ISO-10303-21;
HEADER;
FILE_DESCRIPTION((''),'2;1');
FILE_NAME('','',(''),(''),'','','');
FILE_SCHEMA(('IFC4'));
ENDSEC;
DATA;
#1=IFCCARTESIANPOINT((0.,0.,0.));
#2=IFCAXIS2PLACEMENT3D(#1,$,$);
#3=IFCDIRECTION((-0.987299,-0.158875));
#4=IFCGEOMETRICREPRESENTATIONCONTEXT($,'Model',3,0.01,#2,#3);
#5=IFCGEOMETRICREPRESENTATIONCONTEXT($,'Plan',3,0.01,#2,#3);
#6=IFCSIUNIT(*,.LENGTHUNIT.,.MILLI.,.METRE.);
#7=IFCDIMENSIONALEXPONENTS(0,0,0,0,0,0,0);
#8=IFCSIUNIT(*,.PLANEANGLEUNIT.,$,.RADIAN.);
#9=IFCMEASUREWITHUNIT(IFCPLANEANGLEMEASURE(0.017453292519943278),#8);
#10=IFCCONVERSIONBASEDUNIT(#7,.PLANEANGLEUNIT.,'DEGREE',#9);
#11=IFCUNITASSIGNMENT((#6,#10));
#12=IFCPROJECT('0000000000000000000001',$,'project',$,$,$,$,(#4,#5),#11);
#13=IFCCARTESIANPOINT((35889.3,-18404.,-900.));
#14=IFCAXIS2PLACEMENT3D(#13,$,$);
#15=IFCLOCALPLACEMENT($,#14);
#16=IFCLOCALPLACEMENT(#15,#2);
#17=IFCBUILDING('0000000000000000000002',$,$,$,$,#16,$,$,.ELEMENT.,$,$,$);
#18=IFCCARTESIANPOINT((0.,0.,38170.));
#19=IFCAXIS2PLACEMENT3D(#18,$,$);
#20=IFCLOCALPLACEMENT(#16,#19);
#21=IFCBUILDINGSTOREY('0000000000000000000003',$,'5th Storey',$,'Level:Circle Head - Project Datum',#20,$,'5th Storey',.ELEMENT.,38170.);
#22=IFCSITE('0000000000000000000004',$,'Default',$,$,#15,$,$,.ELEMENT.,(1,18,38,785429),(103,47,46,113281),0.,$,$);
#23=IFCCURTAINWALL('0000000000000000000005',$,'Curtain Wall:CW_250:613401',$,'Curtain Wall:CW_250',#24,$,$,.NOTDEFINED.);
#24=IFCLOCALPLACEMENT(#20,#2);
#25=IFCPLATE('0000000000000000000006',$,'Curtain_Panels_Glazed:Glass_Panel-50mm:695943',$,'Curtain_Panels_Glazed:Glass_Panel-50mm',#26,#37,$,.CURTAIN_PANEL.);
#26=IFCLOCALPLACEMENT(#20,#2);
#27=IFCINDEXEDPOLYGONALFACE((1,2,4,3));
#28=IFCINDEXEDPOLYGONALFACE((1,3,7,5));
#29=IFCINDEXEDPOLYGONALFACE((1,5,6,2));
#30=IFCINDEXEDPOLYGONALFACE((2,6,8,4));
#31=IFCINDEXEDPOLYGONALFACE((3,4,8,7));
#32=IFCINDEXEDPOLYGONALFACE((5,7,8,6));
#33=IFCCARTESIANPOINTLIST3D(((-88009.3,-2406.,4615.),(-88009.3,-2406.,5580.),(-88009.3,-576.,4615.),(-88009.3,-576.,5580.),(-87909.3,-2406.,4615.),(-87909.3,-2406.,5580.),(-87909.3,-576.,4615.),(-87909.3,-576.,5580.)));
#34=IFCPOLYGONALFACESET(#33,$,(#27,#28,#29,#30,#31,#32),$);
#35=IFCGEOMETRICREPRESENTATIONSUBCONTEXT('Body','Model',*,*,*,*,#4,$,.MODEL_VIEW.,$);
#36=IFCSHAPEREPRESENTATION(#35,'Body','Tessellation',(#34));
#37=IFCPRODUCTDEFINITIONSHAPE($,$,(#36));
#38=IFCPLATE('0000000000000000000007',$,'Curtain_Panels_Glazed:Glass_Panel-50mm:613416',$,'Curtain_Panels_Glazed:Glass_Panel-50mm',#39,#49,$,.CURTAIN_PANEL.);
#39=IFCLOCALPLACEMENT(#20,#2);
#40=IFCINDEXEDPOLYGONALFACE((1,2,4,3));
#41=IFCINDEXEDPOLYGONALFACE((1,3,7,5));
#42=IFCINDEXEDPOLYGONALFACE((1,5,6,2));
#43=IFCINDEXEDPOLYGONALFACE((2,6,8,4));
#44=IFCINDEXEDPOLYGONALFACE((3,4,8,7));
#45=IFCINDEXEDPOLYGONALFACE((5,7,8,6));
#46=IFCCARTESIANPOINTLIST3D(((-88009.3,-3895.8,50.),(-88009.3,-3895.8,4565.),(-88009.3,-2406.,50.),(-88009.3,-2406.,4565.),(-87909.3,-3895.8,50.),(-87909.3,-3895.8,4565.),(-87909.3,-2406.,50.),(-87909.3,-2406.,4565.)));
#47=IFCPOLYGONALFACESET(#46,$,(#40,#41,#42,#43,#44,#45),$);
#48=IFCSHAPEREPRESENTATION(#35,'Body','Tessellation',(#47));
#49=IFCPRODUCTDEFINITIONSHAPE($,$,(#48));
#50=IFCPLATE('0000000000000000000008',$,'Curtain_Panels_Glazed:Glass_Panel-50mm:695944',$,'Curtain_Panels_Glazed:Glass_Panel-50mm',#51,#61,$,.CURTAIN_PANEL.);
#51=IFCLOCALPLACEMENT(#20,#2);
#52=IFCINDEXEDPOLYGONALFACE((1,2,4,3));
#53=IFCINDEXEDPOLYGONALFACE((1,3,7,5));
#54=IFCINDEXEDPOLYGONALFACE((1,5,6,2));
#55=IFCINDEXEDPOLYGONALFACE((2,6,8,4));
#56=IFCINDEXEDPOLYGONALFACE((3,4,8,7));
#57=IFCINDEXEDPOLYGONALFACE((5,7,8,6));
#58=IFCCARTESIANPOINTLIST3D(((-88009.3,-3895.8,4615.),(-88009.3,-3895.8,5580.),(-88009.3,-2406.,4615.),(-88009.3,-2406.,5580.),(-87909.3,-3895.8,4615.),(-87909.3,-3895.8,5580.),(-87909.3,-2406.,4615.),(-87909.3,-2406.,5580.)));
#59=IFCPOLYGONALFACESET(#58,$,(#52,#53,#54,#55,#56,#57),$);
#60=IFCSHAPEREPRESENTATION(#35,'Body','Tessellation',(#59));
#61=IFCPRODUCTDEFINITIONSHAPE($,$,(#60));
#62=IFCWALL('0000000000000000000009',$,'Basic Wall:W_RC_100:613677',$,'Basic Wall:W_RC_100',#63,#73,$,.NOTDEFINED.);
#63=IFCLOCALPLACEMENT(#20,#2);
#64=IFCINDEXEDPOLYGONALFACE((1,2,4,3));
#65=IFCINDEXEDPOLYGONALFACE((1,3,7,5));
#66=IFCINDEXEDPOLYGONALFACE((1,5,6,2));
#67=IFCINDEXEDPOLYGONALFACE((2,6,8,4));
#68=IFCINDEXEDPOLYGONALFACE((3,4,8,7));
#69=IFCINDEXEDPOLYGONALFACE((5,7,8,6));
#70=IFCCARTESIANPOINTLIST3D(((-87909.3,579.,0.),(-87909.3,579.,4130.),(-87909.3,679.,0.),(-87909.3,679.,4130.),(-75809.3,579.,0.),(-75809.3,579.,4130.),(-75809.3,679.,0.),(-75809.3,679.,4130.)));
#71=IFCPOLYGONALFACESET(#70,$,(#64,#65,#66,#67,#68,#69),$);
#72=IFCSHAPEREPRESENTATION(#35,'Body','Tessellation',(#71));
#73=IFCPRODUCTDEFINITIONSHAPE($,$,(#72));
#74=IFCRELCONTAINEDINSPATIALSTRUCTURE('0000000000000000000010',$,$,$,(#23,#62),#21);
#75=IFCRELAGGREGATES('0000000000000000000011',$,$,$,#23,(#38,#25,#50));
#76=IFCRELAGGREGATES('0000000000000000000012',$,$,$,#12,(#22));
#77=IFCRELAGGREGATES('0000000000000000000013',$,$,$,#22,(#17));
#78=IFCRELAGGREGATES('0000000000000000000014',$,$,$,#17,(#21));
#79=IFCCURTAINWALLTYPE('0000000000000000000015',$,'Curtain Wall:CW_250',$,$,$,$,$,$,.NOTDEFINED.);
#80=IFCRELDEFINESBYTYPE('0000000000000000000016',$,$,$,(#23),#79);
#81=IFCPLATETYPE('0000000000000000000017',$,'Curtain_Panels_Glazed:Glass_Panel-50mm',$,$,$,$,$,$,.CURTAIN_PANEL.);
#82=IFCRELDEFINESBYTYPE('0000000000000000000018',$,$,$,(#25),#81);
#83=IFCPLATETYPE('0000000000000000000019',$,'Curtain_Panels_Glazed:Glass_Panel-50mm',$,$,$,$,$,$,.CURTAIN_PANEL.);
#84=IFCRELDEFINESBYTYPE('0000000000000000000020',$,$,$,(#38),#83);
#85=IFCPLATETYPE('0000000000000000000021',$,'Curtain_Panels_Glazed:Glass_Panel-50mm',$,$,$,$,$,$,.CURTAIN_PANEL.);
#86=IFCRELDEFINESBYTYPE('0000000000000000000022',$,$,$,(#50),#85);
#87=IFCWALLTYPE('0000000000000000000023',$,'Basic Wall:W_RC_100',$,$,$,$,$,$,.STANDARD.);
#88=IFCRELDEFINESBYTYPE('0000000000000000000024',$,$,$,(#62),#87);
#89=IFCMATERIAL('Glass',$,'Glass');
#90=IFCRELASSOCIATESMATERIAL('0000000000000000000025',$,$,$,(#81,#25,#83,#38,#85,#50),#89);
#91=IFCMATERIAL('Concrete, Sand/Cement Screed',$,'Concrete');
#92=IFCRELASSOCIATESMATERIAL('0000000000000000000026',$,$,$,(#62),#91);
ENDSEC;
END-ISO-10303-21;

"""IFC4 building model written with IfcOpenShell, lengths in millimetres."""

from ifc_helpers import new_model, entity, si_unit, converted_unit, direction, frame, origin, place, context, subcontext, project, spatial, indexed_curve, outline, extrude, source, transform, mapped, material, type_object, type_shapes, element, aggregate, save


model = new_model("IFC4")

# Units and contexts
model_context = context("Model", 3, precision=0.01, world=origin(), true_north=direction((-0.987299, -0.158875)))
plan_context = context("Plan", 3, precision=0.01, world=origin(), true_north=direction((-0.987299, -0.158875)))
body_context = subcontext(model_context, "Body", "Model", "MODEL_VIEW")
ifc_project = project(units=[si_unit("LENGTHUNIT", "METRE", prefix="MILLI"), converted_unit("PLANEANGLEUNIT", "DEGREE", entity("IfcPlaneAngleMeasure", 0.017453292519943278), si_unit("PLANEANGLEUNIT", "RADIAN"), dimensions=[0, 0, 0, 0, 0, 0, 0])], contexts=[model_context, plan_context])

# Site, building, storey
site_placement = place(None, frame((35889.3, -18404.0, -900.0)))
site = spatial("IfcSite", under=ifc_project, at=site_placement, Name="Default", CompositionType="ELEMENT", RefLatitude=(1, 18, 38, 785429), RefLongitude=(103, 47, 46, 113281), RefElevation=0.0)
building_placement = place(site_placement, origin())
building = spatial("IfcBuilding", under=site, at=building_placement, CompositionType="ELEMENT")
storey_placement = place(building_placement, frame((0.0, 0.0, 38170.0)))
storey = spatial("IfcBuildingStorey", under=building, at=storey_placement, Name="5th Storey", ObjectType="Level:Circle Head - Project Datum", LongName="5th Storey", CompositionType="ELEMENT", Elevation=38170.0)

# Curtain wall
curtain_wall_type = type_object("IfcCurtainWallType", Name="Curtain Wall:CW_250", PredefinedType="NOTDEFINED")
curtain_wall_1_placement = place(storey_placement, frame((0.0, 0.0, -38170.0)))
curtain_wall_1 = element("IfcCurtainWall", 1, at=curtain_wall_1_placement, inside=storey, type_object=curtain_wall_type, Name="Curtain Wall:CW_250:613401", ObjectType="Curtain Wall:CW_250", PredefinedType="NOTDEFINED")

# Plates
ifc_material_1 = material(Name="Glass", Category="Glass")
plate_type_1 = type_object("IfcPlateType", Name="Curtain_Panels_Glazed:Glass_Panel-50mm", PredefinedType="CURTAIN_PANEL", material=ifc_material_1)
shared_shape_1 = source(origin(), body_context, "Body", "SweptSolid", [
    extrude(outline(indexed_curve([(-50.0, -915.0), (50.0, -915.0), (50.0, 915.0), (-50.0, 915.0), (-50.0, -915.0)], self_intersect=False)), frame((0.0, 200.0, 0.0), z_axis=(0.0, 0.0, 1.0), x_axis=(0.0, 1.0, 0.0)), (0.0, 0.0, 1.0), 965.0),
])
type_shapes(plate_type_1, [shared_shape_1])
plate_1_placement = place(curtain_wall_1_placement, frame((-88159.3, -1491.0, 42785.0), z_axis=(0.0, 0.0, 1.0), x_axis=(0.0, -1.0, 0.0)))
plate_1 = element("IfcPlate", 2, at=plate_1_placement, type_object=plate_type_1, material=ifc_material_1, Name="Curtain_Panels_Glazed:Glass_Panel-50mm:695943", ObjectType="Curtain_Panels_Glazed:Glass_Panel-50mm", PredefinedType="CURTAIN_PANEL", context=body_context, shape_type="MappedRepresentation", body=[
    mapped(shared_shape_1, transform((0.0, 0.0, 0.0), scale=1.0)),
])
plate_type_2 = type_object("IfcPlateType", Name="Curtain_Panels_Glazed:Glass_Panel-50mm", PredefinedType="CURTAIN_PANEL", material=ifc_material_1)
shared_shape_2 = source(origin(), body_context, "Body", "SweptSolid", [
    extrude(outline(indexed_curve([(-50.0, -744.9), (50.0, -744.9), (50.0, 744.9), (-50.0, 744.9), (-50.0, -744.9)], self_intersect=False)), frame((0.0, 200.0, 0.0), z_axis=(0.0, 0.0, 1.0), x_axis=(0.0, 1.0, 0.0)), (0.0, 0.0, 1.0), 4515.0),
])
type_shapes(plate_type_2, [shared_shape_2])
plate_2_placement = place(curtain_wall_1_placement, frame((-88159.3, -3150.9, 38220.0), z_axis=(0.0, 0.0, 1.0), x_axis=(0.0, -1.0, 0.0)))
plate_2 = element("IfcPlate", 3, at=plate_2_placement, type_object=plate_type_2, material=ifc_material_1, Name="Curtain_Panels_Glazed:Glass_Panel-50mm:613416", ObjectType="Curtain_Panels_Glazed:Glass_Panel-50mm", PredefinedType="CURTAIN_PANEL", context=body_context, shape_type="MappedRepresentation", body=[
    mapped(shared_shape_2, transform((0.0, 0.0, 0.0), scale=1.0)),
])
plate_type_3 = type_object("IfcPlateType", Name="Curtain_Panels_Glazed:Glass_Panel-50mm", PredefinedType="CURTAIN_PANEL", material=ifc_material_1)
shared_shape_3 = source(origin(), body_context, "Body", "SweptSolid", [
    extrude(outline(indexed_curve([(-50.0, -744.9), (50.0, -744.9), (50.0, 744.9), (-50.0, 744.9), (-50.0, -744.9)], self_intersect=False)), frame((0.0, 200.0, 0.0), z_axis=(0.0, 0.0, 1.0), x_axis=(0.0, 1.0, 0.0)), (0.0, 0.0, 1.0), 965.0),
])
type_shapes(plate_type_3, [shared_shape_3])
plate_3_placement = place(curtain_wall_1_placement, frame((-88159.3, -3150.9, 42785.0), z_axis=(0.0, 0.0, 1.0), x_axis=(0.0, -1.0, 0.0)))
plate_3 = element("IfcPlate", 4, at=plate_3_placement, type_object=plate_type_3, material=ifc_material_1, Name="Curtain_Panels_Glazed:Glass_Panel-50mm:695944", ObjectType="Curtain_Panels_Glazed:Glass_Panel-50mm", PredefinedType="CURTAIN_PANEL", context=body_context, shape_type="MappedRepresentation", body=[
    mapped(shared_shape_3, transform((0.0, 0.0, 0.0), scale=1.0)),
])
aggregate(curtain_wall_1, [plate_2, plate_1, plate_3])

# Wall
ifc_material_2 = material(Name="Concrete, Sand/Cement Screed", Category="Concrete")
wall_type = type_object("IfcWallType", Name="Basic Wall:W_RC_100", PredefinedType="STANDARD")
wall_placement = place(storey_placement, frame((-87909.3, 629.0, 0.0)))
element("IfcWall", 5, at=wall_placement, inside=storey, type_object=wall_type, material=ifc_material_2, Name="Basic Wall:W_RC_100:613677", ObjectType="Basic Wall:W_RC_100", PredefinedType="NOTDEFINED", context=body_context, shape_type="SweptSolid", body=[
    extrude(outline(indexed_curve([(12100.0, 50.0), (0.0, 50.0), (0.0, -50.0), (12100.0, -50.0), (12100.0, 50.0)], self_intersect=False)), origin(), (0.0, 0.0, 1.0), 4130.0),
])

save(model, "model.ifc")
